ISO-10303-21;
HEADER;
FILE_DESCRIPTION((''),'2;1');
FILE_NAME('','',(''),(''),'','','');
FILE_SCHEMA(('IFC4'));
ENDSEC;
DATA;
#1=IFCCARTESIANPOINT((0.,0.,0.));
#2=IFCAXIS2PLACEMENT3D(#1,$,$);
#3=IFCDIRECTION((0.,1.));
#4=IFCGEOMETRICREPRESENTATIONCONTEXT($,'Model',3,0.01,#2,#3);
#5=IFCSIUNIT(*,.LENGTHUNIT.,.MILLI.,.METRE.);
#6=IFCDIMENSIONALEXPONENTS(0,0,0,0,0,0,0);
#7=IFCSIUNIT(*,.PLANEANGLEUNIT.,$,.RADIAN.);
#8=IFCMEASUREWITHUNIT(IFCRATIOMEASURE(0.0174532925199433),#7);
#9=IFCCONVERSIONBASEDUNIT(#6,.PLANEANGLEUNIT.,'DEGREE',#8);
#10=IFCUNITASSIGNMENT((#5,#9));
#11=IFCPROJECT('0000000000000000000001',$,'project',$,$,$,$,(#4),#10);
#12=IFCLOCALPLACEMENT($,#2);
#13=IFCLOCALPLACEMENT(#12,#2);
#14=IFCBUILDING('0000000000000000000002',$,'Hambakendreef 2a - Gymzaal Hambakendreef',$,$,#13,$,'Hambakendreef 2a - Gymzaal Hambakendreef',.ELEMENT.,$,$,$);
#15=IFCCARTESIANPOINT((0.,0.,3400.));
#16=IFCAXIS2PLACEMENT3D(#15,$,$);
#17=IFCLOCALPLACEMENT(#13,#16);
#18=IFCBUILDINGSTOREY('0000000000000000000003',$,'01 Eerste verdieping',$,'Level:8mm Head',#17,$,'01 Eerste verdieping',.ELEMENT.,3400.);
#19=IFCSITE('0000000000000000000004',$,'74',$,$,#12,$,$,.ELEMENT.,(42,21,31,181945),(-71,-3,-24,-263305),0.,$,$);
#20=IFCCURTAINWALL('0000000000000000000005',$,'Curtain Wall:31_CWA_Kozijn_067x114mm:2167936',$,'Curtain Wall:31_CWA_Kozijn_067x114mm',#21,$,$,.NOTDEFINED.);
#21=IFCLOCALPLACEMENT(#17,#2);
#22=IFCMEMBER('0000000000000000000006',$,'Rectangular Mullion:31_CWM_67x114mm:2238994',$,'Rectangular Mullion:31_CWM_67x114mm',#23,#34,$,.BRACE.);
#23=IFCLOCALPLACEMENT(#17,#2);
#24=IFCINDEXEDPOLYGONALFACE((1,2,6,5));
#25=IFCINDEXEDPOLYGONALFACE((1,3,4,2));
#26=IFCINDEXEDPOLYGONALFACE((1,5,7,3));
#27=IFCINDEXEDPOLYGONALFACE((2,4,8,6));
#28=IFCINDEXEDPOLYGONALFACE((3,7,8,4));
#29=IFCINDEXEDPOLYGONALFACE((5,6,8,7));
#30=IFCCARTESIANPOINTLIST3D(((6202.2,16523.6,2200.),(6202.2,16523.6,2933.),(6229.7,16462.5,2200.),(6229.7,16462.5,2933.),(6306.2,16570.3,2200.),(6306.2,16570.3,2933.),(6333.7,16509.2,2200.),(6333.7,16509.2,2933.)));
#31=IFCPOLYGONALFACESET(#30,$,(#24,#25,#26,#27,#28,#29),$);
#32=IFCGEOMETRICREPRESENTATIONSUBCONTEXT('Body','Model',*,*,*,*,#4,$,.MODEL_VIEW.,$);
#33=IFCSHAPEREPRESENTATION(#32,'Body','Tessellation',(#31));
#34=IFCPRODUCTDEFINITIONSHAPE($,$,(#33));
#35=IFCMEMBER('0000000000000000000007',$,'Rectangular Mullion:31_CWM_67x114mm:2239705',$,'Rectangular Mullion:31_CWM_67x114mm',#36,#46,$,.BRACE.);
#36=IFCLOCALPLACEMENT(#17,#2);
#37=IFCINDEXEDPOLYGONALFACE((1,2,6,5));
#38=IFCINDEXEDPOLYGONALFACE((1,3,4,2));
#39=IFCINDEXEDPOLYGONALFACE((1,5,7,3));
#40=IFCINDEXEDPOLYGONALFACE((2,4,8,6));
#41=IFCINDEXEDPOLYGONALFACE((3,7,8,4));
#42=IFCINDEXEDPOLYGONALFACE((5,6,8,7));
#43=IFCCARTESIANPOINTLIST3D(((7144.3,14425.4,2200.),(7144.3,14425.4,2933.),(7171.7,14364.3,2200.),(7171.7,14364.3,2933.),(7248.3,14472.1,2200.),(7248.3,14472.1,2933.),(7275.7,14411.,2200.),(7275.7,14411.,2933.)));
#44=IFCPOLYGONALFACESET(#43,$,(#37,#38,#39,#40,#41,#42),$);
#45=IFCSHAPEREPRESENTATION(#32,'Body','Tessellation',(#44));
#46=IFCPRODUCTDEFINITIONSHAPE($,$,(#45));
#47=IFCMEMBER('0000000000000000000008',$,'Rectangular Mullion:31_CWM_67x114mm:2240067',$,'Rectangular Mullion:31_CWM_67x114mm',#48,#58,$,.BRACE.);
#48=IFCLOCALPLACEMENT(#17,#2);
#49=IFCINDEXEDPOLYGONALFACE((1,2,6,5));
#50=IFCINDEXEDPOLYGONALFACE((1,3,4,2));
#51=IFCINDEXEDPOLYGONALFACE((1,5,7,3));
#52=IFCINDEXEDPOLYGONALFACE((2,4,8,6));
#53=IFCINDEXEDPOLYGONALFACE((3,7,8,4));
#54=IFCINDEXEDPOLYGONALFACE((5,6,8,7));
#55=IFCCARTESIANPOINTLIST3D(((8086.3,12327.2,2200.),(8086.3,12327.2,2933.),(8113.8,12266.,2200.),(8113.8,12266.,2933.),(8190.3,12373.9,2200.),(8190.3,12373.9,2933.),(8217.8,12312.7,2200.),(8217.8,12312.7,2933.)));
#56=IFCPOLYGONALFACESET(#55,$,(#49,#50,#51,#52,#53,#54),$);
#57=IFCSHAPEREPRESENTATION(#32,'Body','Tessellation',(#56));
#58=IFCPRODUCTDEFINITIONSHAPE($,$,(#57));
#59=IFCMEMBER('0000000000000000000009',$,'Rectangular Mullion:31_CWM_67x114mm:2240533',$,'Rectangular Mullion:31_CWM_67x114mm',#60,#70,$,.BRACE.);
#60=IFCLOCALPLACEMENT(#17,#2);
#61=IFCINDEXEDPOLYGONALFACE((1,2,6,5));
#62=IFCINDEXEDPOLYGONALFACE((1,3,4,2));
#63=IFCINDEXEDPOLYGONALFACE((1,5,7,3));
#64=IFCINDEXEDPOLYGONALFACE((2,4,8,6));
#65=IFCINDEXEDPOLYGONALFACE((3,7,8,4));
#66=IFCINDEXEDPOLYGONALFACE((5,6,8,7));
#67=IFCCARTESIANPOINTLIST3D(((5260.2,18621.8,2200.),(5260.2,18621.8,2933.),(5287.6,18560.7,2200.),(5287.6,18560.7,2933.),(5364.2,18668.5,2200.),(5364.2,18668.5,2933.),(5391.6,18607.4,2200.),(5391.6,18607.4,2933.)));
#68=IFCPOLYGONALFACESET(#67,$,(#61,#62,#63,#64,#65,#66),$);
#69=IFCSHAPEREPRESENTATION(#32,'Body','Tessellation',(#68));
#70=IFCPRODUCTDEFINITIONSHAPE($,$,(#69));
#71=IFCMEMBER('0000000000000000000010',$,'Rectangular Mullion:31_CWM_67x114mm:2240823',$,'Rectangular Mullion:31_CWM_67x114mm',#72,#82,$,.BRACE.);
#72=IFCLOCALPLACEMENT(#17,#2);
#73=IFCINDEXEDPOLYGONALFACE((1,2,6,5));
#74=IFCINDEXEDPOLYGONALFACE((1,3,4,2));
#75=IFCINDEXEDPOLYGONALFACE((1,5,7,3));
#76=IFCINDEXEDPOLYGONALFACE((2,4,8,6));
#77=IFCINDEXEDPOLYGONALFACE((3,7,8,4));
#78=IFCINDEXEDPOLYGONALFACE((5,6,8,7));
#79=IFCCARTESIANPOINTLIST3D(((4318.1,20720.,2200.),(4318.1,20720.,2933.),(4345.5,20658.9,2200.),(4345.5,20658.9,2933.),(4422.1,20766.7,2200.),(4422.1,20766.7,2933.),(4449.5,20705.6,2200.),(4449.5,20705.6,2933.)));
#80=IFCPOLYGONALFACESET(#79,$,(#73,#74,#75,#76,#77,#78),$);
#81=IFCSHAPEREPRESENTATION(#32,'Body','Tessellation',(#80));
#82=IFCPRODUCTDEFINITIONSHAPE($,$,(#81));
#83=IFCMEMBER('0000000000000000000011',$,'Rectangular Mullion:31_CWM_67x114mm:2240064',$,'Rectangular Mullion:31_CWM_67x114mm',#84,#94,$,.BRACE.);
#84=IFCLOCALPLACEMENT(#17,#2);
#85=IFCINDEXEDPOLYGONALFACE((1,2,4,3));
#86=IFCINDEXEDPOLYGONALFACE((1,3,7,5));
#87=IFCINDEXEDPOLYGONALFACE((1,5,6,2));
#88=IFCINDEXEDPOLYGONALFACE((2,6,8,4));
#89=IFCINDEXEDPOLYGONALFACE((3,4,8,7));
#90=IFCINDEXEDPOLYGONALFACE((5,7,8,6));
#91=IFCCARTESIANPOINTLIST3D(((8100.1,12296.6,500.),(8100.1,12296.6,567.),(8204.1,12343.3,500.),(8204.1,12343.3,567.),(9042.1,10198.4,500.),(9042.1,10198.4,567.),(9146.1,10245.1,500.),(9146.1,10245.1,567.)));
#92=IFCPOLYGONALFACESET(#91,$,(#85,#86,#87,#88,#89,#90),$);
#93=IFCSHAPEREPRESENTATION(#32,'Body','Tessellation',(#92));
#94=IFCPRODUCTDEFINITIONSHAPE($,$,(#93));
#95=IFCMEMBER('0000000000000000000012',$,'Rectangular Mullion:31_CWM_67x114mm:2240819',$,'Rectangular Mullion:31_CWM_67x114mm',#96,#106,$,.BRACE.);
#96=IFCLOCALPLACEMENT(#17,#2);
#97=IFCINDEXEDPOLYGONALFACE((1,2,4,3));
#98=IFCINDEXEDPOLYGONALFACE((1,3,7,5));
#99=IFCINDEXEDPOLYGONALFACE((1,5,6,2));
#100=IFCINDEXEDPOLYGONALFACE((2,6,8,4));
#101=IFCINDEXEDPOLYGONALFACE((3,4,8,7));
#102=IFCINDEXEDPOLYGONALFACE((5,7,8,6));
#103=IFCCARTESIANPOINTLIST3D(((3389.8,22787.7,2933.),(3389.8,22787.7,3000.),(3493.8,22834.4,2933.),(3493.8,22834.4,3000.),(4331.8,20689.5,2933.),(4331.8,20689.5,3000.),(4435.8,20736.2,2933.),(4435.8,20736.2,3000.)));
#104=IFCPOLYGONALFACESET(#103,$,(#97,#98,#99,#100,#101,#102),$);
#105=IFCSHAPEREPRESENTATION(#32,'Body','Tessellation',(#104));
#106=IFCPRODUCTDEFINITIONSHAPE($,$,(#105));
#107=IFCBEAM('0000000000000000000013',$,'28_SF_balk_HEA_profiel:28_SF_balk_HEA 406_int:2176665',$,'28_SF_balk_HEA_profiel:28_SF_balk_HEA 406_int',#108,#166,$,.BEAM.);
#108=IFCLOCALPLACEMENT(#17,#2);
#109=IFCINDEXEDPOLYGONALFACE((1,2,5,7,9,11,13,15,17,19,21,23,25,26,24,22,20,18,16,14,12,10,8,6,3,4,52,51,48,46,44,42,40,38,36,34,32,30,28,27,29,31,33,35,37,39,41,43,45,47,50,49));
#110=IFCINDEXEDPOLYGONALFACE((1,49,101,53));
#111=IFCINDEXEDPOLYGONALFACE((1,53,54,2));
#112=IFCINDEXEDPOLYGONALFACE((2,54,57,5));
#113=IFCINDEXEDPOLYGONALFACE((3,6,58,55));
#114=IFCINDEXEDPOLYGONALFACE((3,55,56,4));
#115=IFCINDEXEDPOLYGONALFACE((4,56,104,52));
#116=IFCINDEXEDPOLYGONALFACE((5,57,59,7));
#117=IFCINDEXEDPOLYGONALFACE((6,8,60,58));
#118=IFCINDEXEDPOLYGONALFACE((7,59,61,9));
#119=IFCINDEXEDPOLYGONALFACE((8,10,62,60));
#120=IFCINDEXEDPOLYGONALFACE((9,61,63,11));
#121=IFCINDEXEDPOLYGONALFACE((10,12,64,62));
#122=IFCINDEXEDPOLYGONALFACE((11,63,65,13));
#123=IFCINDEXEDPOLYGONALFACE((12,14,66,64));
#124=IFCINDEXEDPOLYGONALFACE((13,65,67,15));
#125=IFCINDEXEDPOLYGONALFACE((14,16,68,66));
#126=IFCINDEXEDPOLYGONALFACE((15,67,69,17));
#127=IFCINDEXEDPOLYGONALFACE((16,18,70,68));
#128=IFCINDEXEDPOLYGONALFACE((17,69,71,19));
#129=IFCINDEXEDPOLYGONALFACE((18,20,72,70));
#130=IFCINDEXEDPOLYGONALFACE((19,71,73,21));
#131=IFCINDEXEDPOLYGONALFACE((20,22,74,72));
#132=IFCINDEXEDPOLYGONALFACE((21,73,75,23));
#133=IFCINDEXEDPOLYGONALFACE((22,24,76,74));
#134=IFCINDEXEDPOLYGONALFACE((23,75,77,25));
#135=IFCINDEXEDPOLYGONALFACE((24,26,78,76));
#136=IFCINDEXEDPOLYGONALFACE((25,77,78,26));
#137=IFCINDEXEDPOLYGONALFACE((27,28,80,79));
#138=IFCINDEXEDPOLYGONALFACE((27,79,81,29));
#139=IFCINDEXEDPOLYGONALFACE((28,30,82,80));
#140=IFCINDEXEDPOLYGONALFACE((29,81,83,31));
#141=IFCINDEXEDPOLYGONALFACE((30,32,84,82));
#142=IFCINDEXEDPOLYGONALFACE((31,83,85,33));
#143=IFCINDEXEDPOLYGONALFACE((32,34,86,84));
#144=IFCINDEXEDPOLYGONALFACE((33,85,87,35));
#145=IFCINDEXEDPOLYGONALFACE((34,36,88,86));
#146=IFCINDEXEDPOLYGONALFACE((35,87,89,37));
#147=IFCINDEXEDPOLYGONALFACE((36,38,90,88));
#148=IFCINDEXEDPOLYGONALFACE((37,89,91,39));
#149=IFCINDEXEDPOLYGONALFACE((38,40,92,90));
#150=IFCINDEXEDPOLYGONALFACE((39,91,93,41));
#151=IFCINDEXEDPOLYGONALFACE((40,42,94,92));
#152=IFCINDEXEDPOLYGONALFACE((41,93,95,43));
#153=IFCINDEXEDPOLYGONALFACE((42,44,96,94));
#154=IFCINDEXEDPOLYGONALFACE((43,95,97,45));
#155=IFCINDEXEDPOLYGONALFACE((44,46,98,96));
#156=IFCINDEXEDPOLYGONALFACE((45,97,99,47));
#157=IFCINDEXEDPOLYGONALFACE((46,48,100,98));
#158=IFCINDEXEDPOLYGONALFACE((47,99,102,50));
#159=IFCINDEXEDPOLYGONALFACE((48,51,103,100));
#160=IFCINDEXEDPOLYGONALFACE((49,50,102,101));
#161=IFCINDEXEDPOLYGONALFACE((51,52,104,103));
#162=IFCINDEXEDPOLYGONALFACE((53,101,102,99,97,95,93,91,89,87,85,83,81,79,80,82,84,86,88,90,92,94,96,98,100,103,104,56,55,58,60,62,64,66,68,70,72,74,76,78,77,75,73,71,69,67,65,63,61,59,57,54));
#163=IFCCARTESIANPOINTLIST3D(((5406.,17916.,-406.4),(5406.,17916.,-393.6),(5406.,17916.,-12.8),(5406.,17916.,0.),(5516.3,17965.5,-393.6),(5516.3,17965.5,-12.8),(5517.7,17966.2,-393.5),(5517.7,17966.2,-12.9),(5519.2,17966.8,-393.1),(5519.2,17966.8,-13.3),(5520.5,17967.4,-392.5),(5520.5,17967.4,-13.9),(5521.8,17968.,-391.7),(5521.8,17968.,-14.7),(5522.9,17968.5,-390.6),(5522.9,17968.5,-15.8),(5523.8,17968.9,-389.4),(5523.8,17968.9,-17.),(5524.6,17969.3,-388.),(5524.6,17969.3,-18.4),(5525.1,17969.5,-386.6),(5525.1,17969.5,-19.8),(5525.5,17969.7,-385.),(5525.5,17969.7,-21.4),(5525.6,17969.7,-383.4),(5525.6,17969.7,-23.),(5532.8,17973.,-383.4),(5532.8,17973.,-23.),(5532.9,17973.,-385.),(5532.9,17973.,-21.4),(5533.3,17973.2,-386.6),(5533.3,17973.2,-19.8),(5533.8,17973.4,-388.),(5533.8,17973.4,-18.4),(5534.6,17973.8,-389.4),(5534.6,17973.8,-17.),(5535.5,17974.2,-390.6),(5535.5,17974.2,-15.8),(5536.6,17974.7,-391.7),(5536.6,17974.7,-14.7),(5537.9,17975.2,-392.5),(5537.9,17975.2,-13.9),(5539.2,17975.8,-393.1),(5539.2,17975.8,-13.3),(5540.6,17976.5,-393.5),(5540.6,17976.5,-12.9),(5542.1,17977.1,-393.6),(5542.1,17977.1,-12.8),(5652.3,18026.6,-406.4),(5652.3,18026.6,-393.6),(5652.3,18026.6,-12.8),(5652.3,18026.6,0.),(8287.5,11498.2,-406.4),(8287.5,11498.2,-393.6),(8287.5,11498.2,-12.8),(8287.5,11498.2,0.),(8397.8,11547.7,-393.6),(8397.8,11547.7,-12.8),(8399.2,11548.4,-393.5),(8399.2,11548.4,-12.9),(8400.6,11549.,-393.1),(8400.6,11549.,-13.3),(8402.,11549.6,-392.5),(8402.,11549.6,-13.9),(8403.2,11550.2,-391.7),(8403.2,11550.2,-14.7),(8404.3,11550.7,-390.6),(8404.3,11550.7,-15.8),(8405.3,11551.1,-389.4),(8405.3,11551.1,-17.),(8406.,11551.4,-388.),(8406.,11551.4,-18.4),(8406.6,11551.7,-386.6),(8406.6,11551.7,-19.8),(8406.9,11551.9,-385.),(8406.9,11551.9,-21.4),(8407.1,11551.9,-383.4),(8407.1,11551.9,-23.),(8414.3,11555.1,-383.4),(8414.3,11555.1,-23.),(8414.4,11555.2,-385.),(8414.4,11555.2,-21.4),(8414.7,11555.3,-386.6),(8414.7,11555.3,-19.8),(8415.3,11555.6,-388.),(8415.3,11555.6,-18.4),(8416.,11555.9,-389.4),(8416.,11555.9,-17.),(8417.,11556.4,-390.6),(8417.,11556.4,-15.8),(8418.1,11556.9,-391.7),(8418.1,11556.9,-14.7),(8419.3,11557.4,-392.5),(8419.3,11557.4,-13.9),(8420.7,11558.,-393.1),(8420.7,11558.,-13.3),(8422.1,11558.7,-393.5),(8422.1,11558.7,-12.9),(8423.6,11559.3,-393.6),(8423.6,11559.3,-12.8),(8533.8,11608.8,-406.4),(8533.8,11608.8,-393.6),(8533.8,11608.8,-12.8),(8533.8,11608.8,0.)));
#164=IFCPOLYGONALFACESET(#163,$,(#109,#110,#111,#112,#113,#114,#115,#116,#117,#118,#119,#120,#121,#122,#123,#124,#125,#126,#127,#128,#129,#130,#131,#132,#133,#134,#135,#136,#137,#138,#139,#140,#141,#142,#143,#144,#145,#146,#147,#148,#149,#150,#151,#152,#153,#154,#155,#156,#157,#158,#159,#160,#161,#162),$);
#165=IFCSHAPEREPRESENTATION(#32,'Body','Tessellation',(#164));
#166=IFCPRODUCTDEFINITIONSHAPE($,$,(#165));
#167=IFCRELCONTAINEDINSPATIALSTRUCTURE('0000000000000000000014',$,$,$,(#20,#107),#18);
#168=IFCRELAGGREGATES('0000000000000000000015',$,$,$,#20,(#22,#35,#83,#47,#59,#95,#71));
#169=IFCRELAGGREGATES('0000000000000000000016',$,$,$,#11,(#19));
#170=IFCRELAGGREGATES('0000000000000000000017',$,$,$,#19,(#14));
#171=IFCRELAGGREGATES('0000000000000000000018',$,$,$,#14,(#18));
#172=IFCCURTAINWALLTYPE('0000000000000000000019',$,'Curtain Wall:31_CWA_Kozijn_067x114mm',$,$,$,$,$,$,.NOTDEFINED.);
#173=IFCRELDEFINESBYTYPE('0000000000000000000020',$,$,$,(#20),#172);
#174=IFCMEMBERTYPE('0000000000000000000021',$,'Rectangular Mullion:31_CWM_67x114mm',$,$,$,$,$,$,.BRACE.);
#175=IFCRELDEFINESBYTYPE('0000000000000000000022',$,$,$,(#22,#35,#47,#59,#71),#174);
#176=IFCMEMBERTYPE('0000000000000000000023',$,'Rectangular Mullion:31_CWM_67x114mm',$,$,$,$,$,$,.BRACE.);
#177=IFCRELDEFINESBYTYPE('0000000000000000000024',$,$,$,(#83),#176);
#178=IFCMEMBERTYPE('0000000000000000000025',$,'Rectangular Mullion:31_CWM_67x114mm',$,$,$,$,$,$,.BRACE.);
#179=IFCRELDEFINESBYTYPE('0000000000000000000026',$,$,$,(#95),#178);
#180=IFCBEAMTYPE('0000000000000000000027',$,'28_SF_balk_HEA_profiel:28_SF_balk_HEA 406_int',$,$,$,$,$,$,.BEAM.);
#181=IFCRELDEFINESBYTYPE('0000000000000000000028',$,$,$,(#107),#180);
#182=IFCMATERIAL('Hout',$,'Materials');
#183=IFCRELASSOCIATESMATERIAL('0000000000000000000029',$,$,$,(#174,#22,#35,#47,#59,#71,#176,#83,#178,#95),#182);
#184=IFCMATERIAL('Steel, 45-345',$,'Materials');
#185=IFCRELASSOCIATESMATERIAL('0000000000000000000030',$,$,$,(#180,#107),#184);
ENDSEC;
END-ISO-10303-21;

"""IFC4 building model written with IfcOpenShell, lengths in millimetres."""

from ifc_helpers import new_model, entity, si_unit, converted_unit, direction, frame, origin, place, context, subcontext, project, spatial, indexed_curve, outline, extrude, source, transform, mapped, material, type_object, type_shapes, element, aggregate, save


model = new_model("IFC4")

# Units and contexts
model_context = context("Model", 3, precision=0.01, world=origin(), true_north=direction((0.0, 1.0)))
body_context = subcontext(model_context, "Body", "Model", "MODEL_VIEW")
ifc_project = project(units=[si_unit("LENGTHUNIT", "METRE", prefix="MILLI"), converted_unit("PLANEANGLEUNIT", "DEGREE", entity("IfcRatioMeasure", 0.0174532925199433), si_unit("PLANEANGLEUNIT", "RADIAN"), dimensions=[0, 0, 0, 0, 0, 0, 0])], contexts=[model_context])

# Site, building, storey
site_placement = place(None, origin())
site = spatial("IfcSite", under=ifc_project, at=site_placement, Name="74", CompositionType="ELEMENT", RefLatitude=(42, 21, 31, 181945), RefLongitude=(-71, -3, -24, -263305), RefElevation=0.0)
building_placement = place(site_placement, origin())
building = spatial("IfcBuilding", under=site, at=building_placement, Name="Hambakendreef 2a - Gymzaal Hambakendreef", LongName="Hambakendreef 2a - Gymzaal Hambakendreef", CompositionType="ELEMENT")
storey_placement = place(building_placement, frame((0.0, 0.0, 3400.0)))
storey = spatial("IfcBuildingStorey", under=building, at=storey_placement, Name="01 Eerste verdieping", ObjectType="Level:8mm Head", LongName="01 Eerste verdieping", CompositionType="ELEMENT", Elevation=3400.0)

# Curtain wall, members
curtain_wall_type = type_object("IfcCurtainWallType", Name="Curtain Wall:31_CWA_Kozijn_067x114mm", PredefinedType="NOTDEFINED")
curtain_wall_placement = place(storey_placement, frame((0.0, 0.0, -3400.0)))
curtain_wall = element("IfcCurtainWall", 1, at=curtain_wall_placement, inside=storey, type_object=curtain_wall_type, Name="Curtain Wall:31_CWA_Kozijn_067x114mm:2167936", ObjectType="Curtain Wall:31_CWA_Kozijn_067x114mm", PredefinedType="NOTDEFINED")
ifc_material_1 = material(Name="Hout", Category="Materials")
member_type_1 = type_object("IfcMemberType", Name="Rectangular Mullion:31_CWM_67x114mm", PredefinedType="BRACE", material=ifc_material_1)
shared_shape_1 = source(origin(), body_context, "Body", "SweptSolid", [
    extrude(outline(indexed_curve([(-57.0, -33.5), (57.0, -33.5), (57.0, 33.5), (-57.0, 33.5), (-57.0, -33.5)], self_intersect=False)), frame((0.0, 0.0, -733.0), z_axis=(0.0, 0.0, 1.0), x_axis=(0.0, -1.0, 0.0)), (0.0, 0.0, 1.0), 733.0),
])
type_shapes(member_type_1, [shared_shape_1])
member_1_placement = place(storey_placement, frame((6267.9, 16516.4, 2200.0), z_axis=(0.0, 0.0, -1.0), x_axis=(0.40959, -0.91227, 0.0)))
member_1 = element("IfcMember", 2, at=member_1_placement, type_object=member_type_1, material=ifc_material_1, Name="Rectangular Mullion:31_CWM_67x114mm:2238994", ObjectType="Rectangular Mullion:31_CWM_67x114mm", PredefinedType="BRACE", context=body_context, shape_type="MappedRepresentation", body=[
    mapped(shared_shape_1, transform((0.0, 0.0, 0.0), scale=1.0)),
])
member_2_placement = place(storey_placement, frame((7210.0, 14418.2, 2200.0), z_axis=(0.0, 0.0, -1.0), x_axis=(0.40959, -0.91227, 0.0)))
member_2 = element("IfcMember", 3, at=member_2_placement, type_object=member_type_1, material=ifc_material_1, Name="Rectangular Mullion:31_CWM_67x114mm:2239705", ObjectType="Rectangular Mullion:31_CWM_67x114mm", PredefinedType="BRACE", context=body_context, shape_type="MappedRepresentation", body=[
    mapped(shared_shape_1, transform((0.0, 0.0, 0.0), scale=1.0)),
])
member_3_placement = place(storey_placement, frame((8152.1, 12319.9, 2200.0), z_axis=(0.0, 0.0, -1.0), x_axis=(0.40959, -0.91227, 0.0)))
member_3 = element("IfcMember", 4, at=member_3_placement, type_object=member_type_1, material=ifc_material_1, Name="Rectangular Mullion:31_CWM_67x114mm:2240067", ObjectType="Rectangular Mullion:31_CWM_67x114mm", PredefinedType="BRACE", context=body_context, shape_type="MappedRepresentation", body=[
    mapped(shared_shape_1, transform((0.0, 0.0, 0.0), scale=1.0)),
])
member_4_placement = place(storey_placement, frame((5325.9, 18614.6, 2200.0), z_axis=(0.0, 0.0, -1.0), x_axis=(0.40959, -0.91227, 0.0)))
member_4 = element("IfcMember", 5, at=member_4_placement, type_object=member_type_1, material=ifc_material_1, Name="Rectangular Mullion:31_CWM_67x114mm:2240533", ObjectType="Rectangular Mullion:31_CWM_67x114mm", PredefinedType="BRACE", context=body_context, shape_type="MappedRepresentation", body=[
    mapped(shared_shape_1, transform((0.0, 0.0, 0.0), scale=1.0)),
])
member_5_placement = place(storey_placement, frame((4383.8, 20712.8, 2200.0), z_axis=(0.0, 0.0, -1.0), x_axis=(0.40959, -0.91227, 0.0)))
member_5 = element("IfcMember", 6, at=member_5_placement, type_object=member_type_1, material=ifc_material_1, Name="Rectangular Mullion:31_CWM_67x114mm:2240823", ObjectType="Rectangular Mullion:31_CWM_67x114mm", PredefinedType="BRACE", context=body_context, shape_type="MappedRepresentation", body=[
    mapped(shared_shape_1, transform((0.0, 0.0, 0.0), scale=1.0)),
])
member_type_2 = type_object("IfcMemberType", Name="Rectangular Mullion:31_CWM_67x114mm", PredefinedType="BRACE", material=ifc_material_1)
shared_shape_2 = source(origin(), body_context, "Body", "SweptSolid", [
    extrude(outline(indexed_curve([(-57.0, -33.5), (57.0, -33.5), (57.0, 33.5), (-57.0, 33.5), (-57.0, -33.5)], self_intersect=False)), frame((-33.5, 0.0, -2300.0), z_axis=(0.0, 0.0, 1.0), x_axis=(0.0, -1.0, 0.0)), (0.0, 0.0, 1.0), 2300.0),
])
type_shapes(member_type_2, [shared_shape_2])
member_6_placement = place(storey_placement, frame((8152.1, 12319.9, 500.0), z_axis=(-0.40959, 0.91227, 0.0), x_axis=(0.0, 0.0, -1.0)))
member_6 = element("IfcMember", 7, at=member_6_placement, type_object=member_type_2, material=ifc_material_1, Name="Rectangular Mullion:31_CWM_67x114mm:2240064", ObjectType="Rectangular Mullion:31_CWM_67x114mm", PredefinedType="BRACE", context=body_context, shape_type="MappedRepresentation", body=[
    mapped(shared_shape_2, transform((0.0, 0.0, 0.0), scale=1.0)),
])
member_type_3 = type_object("IfcMemberType", Name="Rectangular Mullion:31_CWM_67x114mm", PredefinedType="BRACE", material=ifc_material_1)
shared_shape_3 = source(origin(), body_context, "Body", "SweptSolid", [
    extrude(outline(indexed_curve([(-57.0, -33.5), (57.0, -33.5), (57.0, 33.5), (-57.0, 33.5), (-57.0, -33.5)], self_intersect=False)), frame((-33.5, 0.0, -2300.0), z_axis=(0.0, 0.0, 1.0), x_axis=(0.0, -1.0, 0.0)), (0.0, 0.0, 1.0), 2300.0),
])
type_shapes(member_type_3, [shared_shape_3])
member_7_placement = place(storey_placement, frame((4383.8, 20712.8, 3000.0), z_axis=(0.40959, -0.91227, 0.0), x_axis=(0.0, 0.0, 1.0)))
member_7 = element("IfcMember", 8, at=member_7_placement, type_object=member_type_3, material=ifc_material_1, Name="Rectangular Mullion:31_CWM_67x114mm:2240819", ObjectType="Rectangular Mullion:31_CWM_67x114mm", PredefinedType="BRACE", context=body_context, shape_type="MappedRepresentation", body=[
    mapped(shared_shape_3, transform((0.0, 0.0, 0.0), scale=1.0)),
])
aggregate(curtain_wall, [member_1, member_2, member_6, member_3, member_4, member_7, member_5])

# Beam
ifc_material_2 = material(Name="Steel, 45-345", Category="Materials")
beam_type = type_object("IfcBeamType", Name="28_SF_balk_HEA_profiel:28_SF_balk_HEA 406_int", PredefinedType="BEAM", material=ifc_material_2)
shared_shape_4 = source(origin(), body_context, "Body", "SweptSolid", [
    extrude(outline(indexed_curve([(-203.2, -135.0), (-190.4, -135.0), (-190.4, -14.1), (-190.3, -12.6), (-189.9, -11.0), (-189.3, -9.5), (-188.5, -8.2), (-187.4, -6.9), (-186.2, -5.9), (-184.8, -5.1), (-183.4, -4.4), (-181.8, -4.1), (-180.2, -3.9), (180.2, -3.9), (181.8, -4.1), (183.4, -4.4), (184.8, -5.1), (186.2, -5.9), (187.4, -6.9), (188.5, -8.2), (189.3, -9.5), (189.9, -11.0), (190.3, -12.6), (190.4, -14.1), (190.4, -135.0), (203.2, -135.0), (203.2, 135.0), (190.4, 135.0), (190.4, 14.2), (190.3, 12.6), (189.9, 11.0), (189.3, 9.5), (188.5, 8.2), (187.4, 6.9), (186.2, 5.9), (184.8, 5.1), (183.4, 4.4), (181.8, 4.1), (180.2, 4.0), (-180.2, 4.0), (-181.8, 4.1), (-183.4, 4.4), (-184.8, 5.1), (-186.2, 5.9), (-187.4, 6.9), (-188.5, 8.2), (-189.3, 9.5), (-189.9, 11.0), (-190.3, 12.6), (-190.4, 14.2), (-190.4, 135.0), (-203.2, 135.0), (-203.2, -135.0)], self_intersect=False)), frame((-5588.9, 0.0, 0.0), z_axis=(1.0, 0.0, 0.0), x_axis=(0.0, 0.0, -1.0)), (0.0, 0.0, 1.0), 7035.0),
])
type_shapes(beam_type, [shared_shape_4])
beam_placement = place(storey_placement, frame((7818.4, 12872.7, -203.2), z_axis=(0.0, 0.0, 1.0), x_axis=(0.40959, -0.91227, 0.0)))
element("IfcBeam", 9, at=beam_placement, inside=storey, type_object=beam_type, material=ifc_material_2, Name="28_SF_balk_HEA_profiel:28_SF_balk_HEA 406_int:2176665", ObjectType="28_SF_balk_HEA_profiel:28_SF_balk_HEA 406_int", PredefinedType="BEAM", context=body_context, shape_type="MappedRepresentation", body=[
    mapped(shared_shape_4, transform((0.0, 0.0, 0.0), scale=1.0)),
])

save(model, "model.ifc")
